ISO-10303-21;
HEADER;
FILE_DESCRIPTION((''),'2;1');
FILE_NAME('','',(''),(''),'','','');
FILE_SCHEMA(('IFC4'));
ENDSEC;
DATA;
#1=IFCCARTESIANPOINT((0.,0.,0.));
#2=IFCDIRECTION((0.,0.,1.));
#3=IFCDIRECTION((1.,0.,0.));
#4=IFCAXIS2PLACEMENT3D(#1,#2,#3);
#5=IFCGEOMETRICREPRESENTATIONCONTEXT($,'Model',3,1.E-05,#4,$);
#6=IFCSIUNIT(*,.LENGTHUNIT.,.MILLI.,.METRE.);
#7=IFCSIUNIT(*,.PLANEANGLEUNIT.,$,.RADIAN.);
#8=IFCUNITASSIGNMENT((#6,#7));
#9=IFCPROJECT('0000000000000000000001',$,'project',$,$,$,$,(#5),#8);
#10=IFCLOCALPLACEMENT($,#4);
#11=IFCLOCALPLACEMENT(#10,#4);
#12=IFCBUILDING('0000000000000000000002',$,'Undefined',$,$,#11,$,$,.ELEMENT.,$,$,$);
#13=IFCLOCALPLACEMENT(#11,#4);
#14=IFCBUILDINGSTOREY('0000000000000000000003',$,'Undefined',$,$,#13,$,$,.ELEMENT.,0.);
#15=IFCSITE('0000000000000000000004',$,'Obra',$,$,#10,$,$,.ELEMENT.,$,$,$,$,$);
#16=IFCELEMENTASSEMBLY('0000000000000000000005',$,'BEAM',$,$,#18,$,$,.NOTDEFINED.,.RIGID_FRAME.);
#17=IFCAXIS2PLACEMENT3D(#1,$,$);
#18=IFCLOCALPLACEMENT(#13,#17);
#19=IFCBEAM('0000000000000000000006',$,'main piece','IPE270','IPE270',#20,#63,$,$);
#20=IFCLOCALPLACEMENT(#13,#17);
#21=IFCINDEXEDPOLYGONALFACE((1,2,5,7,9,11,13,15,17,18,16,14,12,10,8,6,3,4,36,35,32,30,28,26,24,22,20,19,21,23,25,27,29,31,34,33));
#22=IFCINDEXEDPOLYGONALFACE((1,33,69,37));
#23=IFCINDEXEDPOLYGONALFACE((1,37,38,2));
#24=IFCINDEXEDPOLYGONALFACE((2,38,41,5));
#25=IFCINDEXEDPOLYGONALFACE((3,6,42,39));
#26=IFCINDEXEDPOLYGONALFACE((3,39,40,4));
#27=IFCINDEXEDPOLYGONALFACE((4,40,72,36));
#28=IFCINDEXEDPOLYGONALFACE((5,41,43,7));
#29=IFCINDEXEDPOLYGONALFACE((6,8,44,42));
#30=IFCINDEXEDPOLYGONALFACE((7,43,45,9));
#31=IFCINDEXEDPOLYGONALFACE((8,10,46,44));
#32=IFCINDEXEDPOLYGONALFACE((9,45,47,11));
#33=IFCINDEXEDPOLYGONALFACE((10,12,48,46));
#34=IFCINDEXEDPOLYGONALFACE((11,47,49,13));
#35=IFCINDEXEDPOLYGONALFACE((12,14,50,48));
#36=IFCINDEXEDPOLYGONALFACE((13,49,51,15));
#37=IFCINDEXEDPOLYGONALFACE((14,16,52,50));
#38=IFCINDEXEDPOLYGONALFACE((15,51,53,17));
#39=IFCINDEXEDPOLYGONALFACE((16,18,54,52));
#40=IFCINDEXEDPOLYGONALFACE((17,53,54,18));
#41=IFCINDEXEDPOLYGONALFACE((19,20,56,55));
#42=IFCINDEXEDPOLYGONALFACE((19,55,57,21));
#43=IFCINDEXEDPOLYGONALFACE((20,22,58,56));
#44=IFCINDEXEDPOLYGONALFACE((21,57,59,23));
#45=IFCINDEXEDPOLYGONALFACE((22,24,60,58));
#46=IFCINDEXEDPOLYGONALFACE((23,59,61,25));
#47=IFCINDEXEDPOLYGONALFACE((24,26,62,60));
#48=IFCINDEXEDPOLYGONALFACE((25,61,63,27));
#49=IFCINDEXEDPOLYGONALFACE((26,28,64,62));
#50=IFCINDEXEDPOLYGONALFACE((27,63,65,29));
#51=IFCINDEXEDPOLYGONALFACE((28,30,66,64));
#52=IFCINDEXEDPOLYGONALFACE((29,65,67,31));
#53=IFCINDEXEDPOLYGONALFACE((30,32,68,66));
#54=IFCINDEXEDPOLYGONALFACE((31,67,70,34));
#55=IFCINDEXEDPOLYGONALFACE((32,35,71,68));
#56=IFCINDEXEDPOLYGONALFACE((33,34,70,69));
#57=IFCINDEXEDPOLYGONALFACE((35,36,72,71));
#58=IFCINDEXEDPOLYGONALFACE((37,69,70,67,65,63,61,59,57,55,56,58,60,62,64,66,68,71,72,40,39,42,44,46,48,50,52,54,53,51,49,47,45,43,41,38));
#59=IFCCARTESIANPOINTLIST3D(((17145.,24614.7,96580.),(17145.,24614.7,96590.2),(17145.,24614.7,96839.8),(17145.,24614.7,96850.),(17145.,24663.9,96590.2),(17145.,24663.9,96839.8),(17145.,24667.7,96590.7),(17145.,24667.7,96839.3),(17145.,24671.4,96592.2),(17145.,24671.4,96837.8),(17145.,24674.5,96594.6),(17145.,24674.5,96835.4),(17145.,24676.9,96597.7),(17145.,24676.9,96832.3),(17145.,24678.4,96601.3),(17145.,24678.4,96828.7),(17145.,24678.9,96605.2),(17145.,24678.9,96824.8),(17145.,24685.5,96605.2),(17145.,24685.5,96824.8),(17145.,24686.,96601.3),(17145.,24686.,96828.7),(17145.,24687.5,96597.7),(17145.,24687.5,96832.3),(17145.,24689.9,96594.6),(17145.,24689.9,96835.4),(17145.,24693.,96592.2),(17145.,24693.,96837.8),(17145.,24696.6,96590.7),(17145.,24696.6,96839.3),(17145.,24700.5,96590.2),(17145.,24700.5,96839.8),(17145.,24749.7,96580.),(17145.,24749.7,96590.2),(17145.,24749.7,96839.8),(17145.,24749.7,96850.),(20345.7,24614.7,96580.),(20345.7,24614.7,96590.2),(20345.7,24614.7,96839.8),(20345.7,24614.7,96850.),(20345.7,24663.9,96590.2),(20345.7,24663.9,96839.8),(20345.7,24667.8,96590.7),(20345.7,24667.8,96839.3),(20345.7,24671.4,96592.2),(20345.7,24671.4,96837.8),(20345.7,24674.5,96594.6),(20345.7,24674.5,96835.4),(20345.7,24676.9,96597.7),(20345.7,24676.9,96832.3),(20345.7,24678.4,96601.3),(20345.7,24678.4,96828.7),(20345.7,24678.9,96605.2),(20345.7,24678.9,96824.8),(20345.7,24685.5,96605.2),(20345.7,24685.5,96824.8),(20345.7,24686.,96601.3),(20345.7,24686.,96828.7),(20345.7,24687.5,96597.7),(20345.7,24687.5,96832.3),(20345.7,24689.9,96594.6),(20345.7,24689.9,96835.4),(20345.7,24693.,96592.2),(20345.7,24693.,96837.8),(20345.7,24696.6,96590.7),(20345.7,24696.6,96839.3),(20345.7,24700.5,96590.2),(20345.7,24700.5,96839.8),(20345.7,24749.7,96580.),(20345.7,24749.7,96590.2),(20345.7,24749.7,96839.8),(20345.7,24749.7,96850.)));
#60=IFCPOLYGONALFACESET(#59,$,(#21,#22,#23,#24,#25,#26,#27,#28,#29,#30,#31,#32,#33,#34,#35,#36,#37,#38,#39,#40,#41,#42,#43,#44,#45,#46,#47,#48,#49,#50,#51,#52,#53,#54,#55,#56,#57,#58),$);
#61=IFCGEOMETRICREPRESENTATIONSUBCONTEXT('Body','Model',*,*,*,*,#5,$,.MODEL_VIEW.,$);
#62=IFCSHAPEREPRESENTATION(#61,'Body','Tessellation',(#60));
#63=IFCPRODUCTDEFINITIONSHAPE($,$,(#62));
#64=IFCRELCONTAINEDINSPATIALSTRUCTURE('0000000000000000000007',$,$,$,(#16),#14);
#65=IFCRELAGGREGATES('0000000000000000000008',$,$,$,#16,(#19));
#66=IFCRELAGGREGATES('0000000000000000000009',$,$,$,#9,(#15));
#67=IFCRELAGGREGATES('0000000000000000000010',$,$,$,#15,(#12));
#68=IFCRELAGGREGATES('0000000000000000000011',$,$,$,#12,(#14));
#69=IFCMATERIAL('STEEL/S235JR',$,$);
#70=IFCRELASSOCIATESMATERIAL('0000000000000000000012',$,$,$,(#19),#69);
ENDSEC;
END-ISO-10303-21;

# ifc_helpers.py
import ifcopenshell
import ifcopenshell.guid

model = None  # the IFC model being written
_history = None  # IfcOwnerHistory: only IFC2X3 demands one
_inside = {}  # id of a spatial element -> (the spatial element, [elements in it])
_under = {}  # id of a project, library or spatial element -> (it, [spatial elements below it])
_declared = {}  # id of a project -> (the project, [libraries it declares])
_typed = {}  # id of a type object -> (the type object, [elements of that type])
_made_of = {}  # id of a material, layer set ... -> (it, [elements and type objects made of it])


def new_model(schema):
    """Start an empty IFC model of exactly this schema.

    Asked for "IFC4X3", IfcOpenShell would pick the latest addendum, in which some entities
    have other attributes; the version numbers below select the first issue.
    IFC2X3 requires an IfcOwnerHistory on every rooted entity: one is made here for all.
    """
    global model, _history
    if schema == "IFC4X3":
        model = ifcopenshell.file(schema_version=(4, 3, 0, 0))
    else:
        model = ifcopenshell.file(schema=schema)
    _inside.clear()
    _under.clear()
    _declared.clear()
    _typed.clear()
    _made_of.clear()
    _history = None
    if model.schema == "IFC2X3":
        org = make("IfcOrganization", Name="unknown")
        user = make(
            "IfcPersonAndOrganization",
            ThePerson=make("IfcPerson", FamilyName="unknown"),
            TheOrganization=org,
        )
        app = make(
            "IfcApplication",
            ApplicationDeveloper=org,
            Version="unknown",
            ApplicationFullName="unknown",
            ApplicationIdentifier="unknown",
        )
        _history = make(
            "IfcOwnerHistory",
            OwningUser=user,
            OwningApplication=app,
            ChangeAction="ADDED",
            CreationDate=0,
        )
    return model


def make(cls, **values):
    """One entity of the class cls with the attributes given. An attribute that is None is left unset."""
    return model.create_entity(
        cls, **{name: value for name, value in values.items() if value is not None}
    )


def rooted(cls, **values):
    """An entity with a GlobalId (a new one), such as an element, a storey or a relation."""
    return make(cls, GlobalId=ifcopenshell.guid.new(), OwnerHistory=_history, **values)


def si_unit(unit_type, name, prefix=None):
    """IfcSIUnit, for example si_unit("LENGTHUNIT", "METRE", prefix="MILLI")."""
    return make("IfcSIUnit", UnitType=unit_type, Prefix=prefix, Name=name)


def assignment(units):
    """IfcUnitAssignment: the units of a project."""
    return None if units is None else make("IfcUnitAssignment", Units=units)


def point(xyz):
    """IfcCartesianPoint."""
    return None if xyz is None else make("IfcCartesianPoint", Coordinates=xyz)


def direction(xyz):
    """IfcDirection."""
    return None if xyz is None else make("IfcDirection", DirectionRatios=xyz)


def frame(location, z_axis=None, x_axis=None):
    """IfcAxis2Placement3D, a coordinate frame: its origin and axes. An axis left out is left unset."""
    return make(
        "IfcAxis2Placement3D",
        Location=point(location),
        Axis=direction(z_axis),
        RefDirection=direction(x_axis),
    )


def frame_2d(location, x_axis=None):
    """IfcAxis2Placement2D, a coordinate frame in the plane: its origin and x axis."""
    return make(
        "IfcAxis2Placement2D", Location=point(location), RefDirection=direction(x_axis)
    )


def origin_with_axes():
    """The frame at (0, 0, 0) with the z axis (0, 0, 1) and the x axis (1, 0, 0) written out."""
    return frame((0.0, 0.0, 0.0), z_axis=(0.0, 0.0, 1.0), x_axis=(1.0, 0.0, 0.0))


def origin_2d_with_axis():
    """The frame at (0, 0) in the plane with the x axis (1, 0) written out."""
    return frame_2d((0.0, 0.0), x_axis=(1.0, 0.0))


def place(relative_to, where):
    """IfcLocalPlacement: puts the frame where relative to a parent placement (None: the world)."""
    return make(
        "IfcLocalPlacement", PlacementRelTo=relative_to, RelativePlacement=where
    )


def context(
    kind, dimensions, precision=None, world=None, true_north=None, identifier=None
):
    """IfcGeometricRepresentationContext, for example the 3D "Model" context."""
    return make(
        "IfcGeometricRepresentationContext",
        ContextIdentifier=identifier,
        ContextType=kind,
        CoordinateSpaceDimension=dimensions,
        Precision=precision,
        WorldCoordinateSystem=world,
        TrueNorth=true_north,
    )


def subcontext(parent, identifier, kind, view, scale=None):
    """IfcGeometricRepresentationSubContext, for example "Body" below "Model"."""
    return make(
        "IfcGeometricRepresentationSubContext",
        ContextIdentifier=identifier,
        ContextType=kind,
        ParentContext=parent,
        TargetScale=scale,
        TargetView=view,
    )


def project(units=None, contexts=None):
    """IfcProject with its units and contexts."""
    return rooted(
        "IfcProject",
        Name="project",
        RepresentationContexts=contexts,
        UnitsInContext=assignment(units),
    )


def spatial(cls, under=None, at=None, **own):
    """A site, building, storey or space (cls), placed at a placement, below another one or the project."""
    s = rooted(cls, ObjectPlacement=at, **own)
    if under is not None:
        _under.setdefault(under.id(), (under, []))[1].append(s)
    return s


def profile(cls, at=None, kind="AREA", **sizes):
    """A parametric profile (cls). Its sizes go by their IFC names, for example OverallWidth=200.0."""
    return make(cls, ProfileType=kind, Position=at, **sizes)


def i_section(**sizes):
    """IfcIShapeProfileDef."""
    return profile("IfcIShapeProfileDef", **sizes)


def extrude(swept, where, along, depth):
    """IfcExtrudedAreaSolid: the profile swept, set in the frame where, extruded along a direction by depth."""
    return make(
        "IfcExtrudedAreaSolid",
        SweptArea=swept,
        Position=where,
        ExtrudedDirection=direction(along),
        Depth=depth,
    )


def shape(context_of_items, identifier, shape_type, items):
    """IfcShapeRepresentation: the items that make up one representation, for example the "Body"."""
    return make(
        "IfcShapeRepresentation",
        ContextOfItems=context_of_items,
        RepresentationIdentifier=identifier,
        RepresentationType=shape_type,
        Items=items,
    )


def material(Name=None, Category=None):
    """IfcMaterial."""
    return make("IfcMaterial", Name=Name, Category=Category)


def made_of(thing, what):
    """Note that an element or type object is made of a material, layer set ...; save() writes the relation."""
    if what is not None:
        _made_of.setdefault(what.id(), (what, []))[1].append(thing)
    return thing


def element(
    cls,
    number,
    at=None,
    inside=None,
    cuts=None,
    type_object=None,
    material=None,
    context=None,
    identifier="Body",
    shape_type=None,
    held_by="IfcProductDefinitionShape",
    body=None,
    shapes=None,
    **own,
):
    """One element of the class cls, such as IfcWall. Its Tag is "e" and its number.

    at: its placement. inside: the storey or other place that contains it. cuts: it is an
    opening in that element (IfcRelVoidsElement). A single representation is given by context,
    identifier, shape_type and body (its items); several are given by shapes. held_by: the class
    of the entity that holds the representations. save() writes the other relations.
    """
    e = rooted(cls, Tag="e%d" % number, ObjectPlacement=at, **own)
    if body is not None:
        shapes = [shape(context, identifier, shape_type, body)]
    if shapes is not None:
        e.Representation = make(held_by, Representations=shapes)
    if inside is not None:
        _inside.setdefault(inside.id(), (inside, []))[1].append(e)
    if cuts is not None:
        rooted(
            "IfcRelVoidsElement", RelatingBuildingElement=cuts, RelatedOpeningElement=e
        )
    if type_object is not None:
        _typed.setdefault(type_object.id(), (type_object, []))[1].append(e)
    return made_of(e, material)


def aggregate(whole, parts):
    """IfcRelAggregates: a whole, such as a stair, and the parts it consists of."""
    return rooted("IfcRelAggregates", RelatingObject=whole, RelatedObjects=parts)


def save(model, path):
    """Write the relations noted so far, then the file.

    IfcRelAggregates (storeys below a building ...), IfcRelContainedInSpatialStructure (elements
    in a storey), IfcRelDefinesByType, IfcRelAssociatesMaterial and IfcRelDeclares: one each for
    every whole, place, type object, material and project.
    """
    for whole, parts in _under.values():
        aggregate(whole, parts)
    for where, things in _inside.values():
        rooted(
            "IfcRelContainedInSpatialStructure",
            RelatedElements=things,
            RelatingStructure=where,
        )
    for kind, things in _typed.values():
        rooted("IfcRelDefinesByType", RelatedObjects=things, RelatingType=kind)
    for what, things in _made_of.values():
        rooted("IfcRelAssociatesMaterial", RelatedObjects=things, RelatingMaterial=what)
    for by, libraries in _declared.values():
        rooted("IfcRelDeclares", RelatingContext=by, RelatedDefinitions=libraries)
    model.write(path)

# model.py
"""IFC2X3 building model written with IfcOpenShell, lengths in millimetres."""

from ifc_helpers import new_model, si_unit, frame, origin_with_axes, origin_2d_with_axis, place, context, subcontext, project, spatial, i_section, extrude, material, element, aggregate, save


model = new_model("IFC2X3")

# Units and contexts
model_context = context("Model", 3, precision=1e-05, world=origin_with_axes())
body_context = subcontext(model_context, "Body", "Model", "MODEL_VIEW")
ifc_project = project(units=[si_unit("LENGTHUNIT", "METRE", prefix="MILLI"), si_unit("PLANEANGLEUNIT", "RADIAN")], contexts=[model_context])

# Site, building, storey
site_placement = place(None, origin_with_axes())
site = spatial("IfcSite", under=ifc_project, at=site_placement, Name="Obra", CompositionType="ELEMENT")
building_placement = place(site_placement, origin_with_axes())
building = spatial("IfcBuilding", under=site, at=building_placement, Name="Undefined", CompositionType="ELEMENT")
storey_placement = place(building_placement, origin_with_axes())
storey = spatial("IfcBuildingStorey", under=building, at=storey_placement, Name="Undefined", CompositionType="ELEMENT", Elevation=0.0)

# Shared definitions
ifc_material = material(Name="STEEL/S235JR")

# Element assembly, beam
assembly_1_placement = place(storey_placement, origin_with_axes())
assembly_1 = element("IfcElementAssembly", 1, at=assembly_1_placement, inside=storey, Name="BEAM", AssemblyPlace="NOTDEFINED", PredefinedType="RIGID_FRAME")
beam_1_placement = place(assembly_1_placement, frame((17145.0, 24682.2, 96715.0), z_axis=(0.0, 0.0, 1.0), x_axis=(1.0, 0.000001, 0.0)))
beam_1 = element("IfcBeam", 2, at=beam_1_placement, material=ifc_material, Name="main piece", Description="IPE270", ObjectType="IPE270", context=body_context, shape_type="SweptSolid", body=[
    extrude(i_section(OverallWidth=135.0, OverallDepth=270.0, WebThickness=6.6, FlangeThickness=10.2, FilletRadius=15.0, at=origin_2d_with_axis()), frame((3200.7, 0.0, 0.0), z_axis=(-1.0, 0.0, 0.0), x_axis=(0.0, -1.0, 0.0)), (0.0, 0.0, 1.0), 3200.7),
])
aggregate(assembly_1, [beam_1])

save(model, "model.ifc")
